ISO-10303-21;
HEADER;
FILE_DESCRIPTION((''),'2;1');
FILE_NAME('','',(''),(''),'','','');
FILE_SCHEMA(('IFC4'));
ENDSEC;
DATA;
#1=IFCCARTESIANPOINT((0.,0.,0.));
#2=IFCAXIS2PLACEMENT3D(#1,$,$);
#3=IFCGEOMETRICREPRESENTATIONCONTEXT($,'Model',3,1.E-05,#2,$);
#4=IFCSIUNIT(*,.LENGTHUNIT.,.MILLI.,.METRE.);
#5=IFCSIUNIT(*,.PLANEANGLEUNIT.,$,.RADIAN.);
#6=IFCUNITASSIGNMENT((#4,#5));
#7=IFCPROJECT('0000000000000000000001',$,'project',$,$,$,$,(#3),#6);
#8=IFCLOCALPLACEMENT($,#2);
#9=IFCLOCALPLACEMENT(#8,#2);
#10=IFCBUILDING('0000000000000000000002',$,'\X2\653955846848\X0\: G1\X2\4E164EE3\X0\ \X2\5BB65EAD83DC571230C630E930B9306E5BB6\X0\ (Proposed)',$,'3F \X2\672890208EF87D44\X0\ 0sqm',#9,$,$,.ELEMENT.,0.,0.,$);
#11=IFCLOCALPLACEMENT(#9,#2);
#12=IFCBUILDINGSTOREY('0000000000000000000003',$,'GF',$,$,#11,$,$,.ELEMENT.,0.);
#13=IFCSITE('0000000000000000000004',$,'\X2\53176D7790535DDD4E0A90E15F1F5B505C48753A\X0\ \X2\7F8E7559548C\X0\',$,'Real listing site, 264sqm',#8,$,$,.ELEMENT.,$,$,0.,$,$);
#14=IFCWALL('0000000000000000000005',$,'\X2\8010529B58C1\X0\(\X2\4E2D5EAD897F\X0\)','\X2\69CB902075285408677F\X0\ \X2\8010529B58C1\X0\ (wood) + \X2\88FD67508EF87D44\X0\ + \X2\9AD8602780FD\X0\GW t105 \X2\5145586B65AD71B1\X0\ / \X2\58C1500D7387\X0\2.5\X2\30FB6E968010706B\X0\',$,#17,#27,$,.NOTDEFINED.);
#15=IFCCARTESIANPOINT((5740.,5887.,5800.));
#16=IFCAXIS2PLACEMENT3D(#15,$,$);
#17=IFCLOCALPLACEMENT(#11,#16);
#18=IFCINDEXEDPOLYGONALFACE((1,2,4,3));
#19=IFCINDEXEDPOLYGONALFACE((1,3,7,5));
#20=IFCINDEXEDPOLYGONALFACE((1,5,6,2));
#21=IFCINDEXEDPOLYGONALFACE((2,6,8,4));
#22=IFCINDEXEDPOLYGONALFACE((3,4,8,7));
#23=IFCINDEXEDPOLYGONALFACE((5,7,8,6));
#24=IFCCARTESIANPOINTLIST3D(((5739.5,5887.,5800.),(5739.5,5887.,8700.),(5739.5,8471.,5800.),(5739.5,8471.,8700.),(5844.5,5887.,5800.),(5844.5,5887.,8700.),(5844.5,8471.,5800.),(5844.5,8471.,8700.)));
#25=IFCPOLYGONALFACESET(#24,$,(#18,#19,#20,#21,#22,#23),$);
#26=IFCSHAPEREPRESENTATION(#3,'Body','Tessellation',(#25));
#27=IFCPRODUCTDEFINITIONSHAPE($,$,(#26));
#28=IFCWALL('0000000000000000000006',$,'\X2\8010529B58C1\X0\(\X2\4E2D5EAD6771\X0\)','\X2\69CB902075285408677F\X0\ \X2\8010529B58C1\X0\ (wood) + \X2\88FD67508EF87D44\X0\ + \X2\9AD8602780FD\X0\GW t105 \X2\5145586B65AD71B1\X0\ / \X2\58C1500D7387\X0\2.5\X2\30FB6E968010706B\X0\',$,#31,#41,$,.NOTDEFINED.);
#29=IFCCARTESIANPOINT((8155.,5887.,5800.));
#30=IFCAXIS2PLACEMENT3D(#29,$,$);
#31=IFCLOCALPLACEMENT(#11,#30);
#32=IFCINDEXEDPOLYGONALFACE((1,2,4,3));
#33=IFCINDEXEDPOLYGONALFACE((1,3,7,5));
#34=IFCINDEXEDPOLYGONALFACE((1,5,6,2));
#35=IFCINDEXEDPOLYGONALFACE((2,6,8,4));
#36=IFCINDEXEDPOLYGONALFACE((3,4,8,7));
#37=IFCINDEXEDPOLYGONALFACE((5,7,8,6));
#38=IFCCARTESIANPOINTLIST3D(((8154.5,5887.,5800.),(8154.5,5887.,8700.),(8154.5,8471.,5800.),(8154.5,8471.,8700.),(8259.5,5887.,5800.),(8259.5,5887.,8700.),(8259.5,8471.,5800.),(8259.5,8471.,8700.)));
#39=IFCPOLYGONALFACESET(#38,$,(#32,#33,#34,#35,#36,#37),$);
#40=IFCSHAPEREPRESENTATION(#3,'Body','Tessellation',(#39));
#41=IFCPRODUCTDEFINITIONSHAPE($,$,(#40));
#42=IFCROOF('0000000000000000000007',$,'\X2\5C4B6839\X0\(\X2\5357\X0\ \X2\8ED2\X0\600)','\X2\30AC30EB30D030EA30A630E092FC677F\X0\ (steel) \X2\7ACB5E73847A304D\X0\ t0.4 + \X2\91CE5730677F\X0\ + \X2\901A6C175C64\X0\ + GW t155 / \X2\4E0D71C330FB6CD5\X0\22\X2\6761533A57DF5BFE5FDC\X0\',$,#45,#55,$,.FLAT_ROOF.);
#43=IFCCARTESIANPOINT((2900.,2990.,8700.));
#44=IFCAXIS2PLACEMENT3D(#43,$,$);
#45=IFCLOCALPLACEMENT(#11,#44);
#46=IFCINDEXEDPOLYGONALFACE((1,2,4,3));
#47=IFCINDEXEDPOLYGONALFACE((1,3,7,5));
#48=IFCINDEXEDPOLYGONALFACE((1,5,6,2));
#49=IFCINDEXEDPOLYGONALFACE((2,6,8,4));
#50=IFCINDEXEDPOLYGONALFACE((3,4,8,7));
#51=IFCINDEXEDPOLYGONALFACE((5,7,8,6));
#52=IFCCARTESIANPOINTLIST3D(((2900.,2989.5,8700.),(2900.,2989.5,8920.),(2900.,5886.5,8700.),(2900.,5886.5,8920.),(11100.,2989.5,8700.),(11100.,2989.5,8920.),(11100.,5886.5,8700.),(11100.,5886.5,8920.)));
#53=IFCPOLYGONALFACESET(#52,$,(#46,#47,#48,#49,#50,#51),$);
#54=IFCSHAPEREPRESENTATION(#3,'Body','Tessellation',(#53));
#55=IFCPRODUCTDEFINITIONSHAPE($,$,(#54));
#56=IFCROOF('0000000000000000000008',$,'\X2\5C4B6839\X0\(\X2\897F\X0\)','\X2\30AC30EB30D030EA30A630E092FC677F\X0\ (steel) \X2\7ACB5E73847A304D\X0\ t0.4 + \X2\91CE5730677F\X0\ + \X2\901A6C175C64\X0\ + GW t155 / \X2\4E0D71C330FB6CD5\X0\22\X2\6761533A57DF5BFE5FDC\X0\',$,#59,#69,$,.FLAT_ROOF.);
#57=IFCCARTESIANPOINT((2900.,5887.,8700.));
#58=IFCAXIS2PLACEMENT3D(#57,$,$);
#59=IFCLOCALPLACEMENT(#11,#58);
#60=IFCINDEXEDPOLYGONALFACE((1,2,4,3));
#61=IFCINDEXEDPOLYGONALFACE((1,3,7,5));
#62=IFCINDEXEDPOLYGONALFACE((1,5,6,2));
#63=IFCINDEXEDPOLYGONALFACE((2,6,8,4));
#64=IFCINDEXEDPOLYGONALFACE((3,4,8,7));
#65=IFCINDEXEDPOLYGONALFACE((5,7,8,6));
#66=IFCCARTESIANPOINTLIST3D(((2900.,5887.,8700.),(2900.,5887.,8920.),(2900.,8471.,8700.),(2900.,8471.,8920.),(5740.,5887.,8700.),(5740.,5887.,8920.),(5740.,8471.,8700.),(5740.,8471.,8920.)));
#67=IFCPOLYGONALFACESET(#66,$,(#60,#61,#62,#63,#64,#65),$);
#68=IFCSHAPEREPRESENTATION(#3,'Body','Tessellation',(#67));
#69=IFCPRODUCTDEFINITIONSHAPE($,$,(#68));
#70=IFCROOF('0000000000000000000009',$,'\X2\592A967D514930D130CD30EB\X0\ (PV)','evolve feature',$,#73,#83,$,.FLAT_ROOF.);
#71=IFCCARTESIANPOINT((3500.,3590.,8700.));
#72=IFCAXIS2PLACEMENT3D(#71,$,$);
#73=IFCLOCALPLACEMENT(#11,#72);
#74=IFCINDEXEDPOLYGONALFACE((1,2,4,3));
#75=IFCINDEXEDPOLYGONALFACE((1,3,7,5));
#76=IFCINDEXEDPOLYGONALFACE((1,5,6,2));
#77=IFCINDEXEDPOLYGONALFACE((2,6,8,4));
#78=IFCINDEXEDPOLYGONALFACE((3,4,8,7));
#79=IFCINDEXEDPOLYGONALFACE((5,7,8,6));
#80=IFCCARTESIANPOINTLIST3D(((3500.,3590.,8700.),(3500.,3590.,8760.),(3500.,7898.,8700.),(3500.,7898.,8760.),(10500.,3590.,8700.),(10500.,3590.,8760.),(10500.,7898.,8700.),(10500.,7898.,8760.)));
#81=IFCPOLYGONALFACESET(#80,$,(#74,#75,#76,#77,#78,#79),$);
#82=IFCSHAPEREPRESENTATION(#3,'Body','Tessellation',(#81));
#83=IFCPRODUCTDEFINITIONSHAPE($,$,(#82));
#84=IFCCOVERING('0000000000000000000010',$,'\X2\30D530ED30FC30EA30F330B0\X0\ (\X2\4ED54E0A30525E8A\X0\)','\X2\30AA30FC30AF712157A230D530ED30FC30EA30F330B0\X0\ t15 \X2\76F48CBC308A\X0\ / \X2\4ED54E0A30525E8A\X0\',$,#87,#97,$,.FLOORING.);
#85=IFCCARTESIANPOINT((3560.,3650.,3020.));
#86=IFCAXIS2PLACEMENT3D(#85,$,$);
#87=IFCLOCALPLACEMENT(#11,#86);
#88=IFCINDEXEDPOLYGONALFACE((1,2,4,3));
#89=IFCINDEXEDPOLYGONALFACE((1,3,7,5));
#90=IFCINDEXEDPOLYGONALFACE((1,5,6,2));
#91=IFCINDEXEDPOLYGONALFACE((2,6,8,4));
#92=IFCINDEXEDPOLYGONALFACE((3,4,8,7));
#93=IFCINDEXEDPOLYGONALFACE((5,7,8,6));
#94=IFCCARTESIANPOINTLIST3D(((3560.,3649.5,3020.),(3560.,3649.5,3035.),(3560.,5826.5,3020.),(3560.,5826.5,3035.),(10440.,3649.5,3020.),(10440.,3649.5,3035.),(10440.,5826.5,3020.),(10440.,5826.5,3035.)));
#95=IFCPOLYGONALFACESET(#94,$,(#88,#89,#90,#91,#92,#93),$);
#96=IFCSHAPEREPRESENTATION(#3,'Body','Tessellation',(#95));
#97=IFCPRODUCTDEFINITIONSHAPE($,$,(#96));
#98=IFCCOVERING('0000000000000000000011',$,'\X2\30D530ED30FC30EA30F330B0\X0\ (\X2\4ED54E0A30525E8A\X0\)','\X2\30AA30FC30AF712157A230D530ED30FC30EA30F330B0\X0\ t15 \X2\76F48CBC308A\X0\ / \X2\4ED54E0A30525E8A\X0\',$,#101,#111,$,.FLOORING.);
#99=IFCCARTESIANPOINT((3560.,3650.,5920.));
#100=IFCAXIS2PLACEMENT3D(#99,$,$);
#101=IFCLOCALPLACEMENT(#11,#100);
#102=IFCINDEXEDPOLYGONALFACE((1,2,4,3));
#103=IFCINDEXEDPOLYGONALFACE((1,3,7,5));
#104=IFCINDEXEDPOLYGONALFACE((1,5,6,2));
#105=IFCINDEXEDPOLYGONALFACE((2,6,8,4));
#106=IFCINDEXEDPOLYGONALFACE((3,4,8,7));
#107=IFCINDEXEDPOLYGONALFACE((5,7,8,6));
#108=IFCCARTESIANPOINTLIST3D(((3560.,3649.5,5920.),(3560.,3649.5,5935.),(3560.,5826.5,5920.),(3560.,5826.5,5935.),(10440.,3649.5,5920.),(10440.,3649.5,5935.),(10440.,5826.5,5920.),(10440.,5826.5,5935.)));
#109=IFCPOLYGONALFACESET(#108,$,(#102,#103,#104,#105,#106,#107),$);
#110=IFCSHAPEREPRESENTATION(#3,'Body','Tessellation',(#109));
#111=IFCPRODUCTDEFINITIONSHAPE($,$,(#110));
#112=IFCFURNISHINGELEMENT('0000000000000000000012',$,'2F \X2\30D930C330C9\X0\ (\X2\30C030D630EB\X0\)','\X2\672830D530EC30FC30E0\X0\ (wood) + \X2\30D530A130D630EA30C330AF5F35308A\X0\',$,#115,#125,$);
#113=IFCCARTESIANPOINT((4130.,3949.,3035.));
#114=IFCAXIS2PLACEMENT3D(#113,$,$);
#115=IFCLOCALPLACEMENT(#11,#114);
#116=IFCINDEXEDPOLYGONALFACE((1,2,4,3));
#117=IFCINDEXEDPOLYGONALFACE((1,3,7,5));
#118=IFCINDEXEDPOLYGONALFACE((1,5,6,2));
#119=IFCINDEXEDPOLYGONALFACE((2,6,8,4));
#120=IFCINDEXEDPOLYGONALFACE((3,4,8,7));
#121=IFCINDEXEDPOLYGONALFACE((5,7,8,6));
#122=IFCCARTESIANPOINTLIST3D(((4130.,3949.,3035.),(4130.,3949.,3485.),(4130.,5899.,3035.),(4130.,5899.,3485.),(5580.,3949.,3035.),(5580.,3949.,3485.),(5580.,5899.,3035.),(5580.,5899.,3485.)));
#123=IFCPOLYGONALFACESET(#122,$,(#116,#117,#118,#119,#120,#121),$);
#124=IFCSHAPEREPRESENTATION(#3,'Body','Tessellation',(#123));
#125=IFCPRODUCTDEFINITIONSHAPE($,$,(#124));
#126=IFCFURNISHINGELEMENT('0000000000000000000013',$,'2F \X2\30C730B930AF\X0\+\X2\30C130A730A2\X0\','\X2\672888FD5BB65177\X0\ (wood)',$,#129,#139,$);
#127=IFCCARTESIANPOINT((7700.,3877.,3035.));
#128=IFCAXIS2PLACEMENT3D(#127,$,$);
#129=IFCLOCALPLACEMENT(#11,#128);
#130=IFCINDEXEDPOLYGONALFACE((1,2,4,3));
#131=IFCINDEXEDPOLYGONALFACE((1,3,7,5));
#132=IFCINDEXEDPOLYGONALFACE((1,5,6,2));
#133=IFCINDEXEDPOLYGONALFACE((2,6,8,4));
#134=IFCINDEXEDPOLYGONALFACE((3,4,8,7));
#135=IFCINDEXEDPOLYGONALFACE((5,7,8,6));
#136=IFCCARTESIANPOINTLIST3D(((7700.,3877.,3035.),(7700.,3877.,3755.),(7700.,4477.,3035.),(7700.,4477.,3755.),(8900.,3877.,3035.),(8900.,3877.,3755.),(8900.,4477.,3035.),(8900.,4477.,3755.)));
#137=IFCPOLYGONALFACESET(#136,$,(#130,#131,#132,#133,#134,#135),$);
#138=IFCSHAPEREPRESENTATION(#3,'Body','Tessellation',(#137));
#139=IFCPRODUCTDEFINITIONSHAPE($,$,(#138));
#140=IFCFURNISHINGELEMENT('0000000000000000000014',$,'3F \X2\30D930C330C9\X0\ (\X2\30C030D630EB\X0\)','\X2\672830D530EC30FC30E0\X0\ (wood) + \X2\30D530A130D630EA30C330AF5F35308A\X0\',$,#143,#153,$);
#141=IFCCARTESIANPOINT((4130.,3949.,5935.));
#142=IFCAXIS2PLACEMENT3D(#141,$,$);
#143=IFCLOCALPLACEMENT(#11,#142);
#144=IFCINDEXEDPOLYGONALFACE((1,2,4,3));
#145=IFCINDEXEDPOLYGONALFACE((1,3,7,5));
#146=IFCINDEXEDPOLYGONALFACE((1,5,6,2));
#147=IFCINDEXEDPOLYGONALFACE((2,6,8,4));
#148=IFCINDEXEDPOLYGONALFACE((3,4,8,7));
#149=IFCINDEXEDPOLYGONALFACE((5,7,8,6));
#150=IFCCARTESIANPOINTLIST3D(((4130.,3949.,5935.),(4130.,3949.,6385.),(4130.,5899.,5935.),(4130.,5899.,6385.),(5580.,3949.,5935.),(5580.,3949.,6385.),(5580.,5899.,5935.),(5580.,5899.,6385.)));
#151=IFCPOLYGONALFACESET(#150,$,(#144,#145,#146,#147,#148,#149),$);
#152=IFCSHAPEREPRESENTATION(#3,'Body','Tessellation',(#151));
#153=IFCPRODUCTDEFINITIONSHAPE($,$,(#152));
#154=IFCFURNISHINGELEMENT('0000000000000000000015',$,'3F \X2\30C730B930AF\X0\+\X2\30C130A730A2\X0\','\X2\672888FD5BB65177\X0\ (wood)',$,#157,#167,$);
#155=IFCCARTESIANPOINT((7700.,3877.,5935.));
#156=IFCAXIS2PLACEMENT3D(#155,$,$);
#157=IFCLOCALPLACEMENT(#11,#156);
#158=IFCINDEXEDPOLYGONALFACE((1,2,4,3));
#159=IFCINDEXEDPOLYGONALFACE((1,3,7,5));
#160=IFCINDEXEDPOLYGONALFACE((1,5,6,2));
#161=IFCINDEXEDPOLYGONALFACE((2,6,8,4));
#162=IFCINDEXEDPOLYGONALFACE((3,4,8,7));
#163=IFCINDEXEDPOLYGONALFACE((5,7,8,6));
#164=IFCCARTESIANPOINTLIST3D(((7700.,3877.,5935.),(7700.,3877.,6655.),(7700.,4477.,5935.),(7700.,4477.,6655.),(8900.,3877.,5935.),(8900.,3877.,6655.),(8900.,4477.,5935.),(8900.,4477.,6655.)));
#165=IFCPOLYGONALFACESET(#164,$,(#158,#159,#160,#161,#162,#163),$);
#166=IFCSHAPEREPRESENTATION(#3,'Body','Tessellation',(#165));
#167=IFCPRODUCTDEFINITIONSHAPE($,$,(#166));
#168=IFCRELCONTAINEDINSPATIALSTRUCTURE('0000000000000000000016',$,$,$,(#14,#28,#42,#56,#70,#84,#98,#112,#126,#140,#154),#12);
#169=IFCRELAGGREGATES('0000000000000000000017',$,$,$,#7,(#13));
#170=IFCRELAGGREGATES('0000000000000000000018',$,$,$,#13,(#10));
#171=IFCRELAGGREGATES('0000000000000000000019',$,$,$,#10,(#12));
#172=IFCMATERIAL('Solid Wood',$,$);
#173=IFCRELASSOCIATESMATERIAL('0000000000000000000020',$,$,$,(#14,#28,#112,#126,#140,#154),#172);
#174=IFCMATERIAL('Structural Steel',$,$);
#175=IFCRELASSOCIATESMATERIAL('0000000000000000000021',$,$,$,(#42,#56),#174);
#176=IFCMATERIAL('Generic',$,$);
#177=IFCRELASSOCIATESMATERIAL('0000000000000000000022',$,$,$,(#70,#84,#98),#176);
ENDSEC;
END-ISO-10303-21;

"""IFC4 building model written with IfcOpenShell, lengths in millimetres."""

from ifc_helpers import new_model, si_unit, frame, frame_2d, origin, place, context, project, spatial, rectangle, extrude, material, element, save


model = new_model("IFC4")

# Units and contexts
model_context = context("Model", 3, precision=1e-05, world=origin())
ifc_project = project(units=[si_unit("LENGTHUNIT", "METRE", prefix="MILLI"), si_unit("PLANEANGLEUNIT", "RADIAN")], contexts=[model_context])

# Site, building, storey
site_placement = place(None, origin())
site = spatial("IfcSite", under=ifc_project, at=site_placement, Name="北海道川上郡弟子屈町 美留和", ObjectType="Real listing site, 264sqm", CompositionType="ELEMENT", RefElevation=0.0)
building_placement = place(site_placement, origin())
building = spatial("IfcBuilding", under=site, at=building_placement, Name="改善案: G1世代 家庭菜園テラスの家 (Proposed)", ObjectType="3F 木造軸組 0sqm", CompositionType="ELEMENT", ElevationOfRefHeight=0.0, ElevationOfTerrain=0.0)
storey_placement = place(building_placement, origin())
storey = spatial("IfcBuildingStorey", under=building, at=storey_placement, Name="GF", CompositionType="ELEMENT", Elevation=0.0)

# Shared definitions
ifc_material_1 = material(Name="Solid Wood")

# Walls
wall_1_placement = place(storey_placement, frame((5740.0, 5887.0, 5800.0)))
element("IfcWall", 1, at=wall_1_placement, inside=storey, material=ifc_material_1, Name="耐力壁(中庭西)", Description="構造用合板 耐力壁 (wood) + 製材軸組 + 高性能GW t105 充填断熱 / 壁倍率2.5・準耐火", PredefinedType="NOTDEFINED", context=model_context, shape_type="SweptSolid", body=[
    extrude(rectangle(XDim=105.0, YDim=2584.0, at=frame_2d((52.0, 1292.0))), frame((5740.0, 5887.0, 5800.0)), (0.0, 0.0, 1.0), 2900.0),
])
wall_2_placement = place(storey_placement, frame((8155.0, 5887.0, 5800.0)))
element("IfcWall", 2, at=wall_2_placement, inside=storey, material=ifc_material_1, Name="耐力壁(中庭東)", Description="構造用合板 耐力壁 (wood) + 製材軸組 + 高性能GW t105 充填断熱 / 壁倍率2.5・準耐火", PredefinedType="NOTDEFINED", context=model_context, shape_type="SweptSolid", body=[
    extrude(rectangle(XDim=105.0, YDim=2584.0, at=frame_2d((52.0, 1292.0))), frame((8155.0, 5887.0, 5800.0)), (0.0, 0.0, 1.0), 2900.0),
])

# Roofs
ifc_material_2 = material(Name="Structural Steel")
roof_1_placement = place(storey_placement, frame((2900.0, 2990.0, 8700.0)))
element("IfcRoof", 3, at=roof_1_placement, inside=storey, material=ifc_material_2, Name="屋根(南 軒600)", Description="ガルバリウム鋼板 (steel) 立平葺き t0.4 + 野地板 + 通気層 + GW t155 / 不燃・法22条区域対応", PredefinedType="FLAT_ROOF", context=model_context, shape_type="SweptSolid", body=[
    extrude(rectangle(XDim=8200.0, YDim=2897.0, at=frame_2d((4100.0, 1448.0))), frame((2900.0, 2990.0, 8700.0)), (0.0, 0.0, 1.0), 220.0),
])
roof_2_placement = place(storey_placement, frame((2900.0, 5887.0, 8700.0)))
element("IfcRoof", 4, at=roof_2_placement, inside=storey, material=ifc_material_2, Name="屋根(西)", Description="ガルバリウム鋼板 (steel) 立平葺き t0.4 + 野地板 + 通気層 + GW t155 / 不燃・法22条区域対応", PredefinedType="FLAT_ROOF", context=model_context, shape_type="SweptSolid", body=[
    extrude(rectangle(XDim=2840.0, YDim=2584.0, at=frame_2d((1420.0, 1292.0))), frame((2900.0, 5887.0, 8700.0)), (0.0, 0.0, 1.0), 220.0),
])
ifc_material_3 = material(Name="Generic")
roof_3_placement = place(storey_placement, frame((3500.0, 3590.0, 8700.0)))
element("IfcRoof", 5, at=roof_3_placement, inside=storey, material=ifc_material_3, Name="太陽光パネル (PV)", Description="evolve feature", PredefinedType="FLAT_ROOF", context=model_context, shape_type="SweptSolid", body=[
    extrude(rectangle(XDim=7000.0, YDim=4308.0, at=frame_2d((3500.0, 2154.0))), frame((3500.0, 3590.0, 8700.0)), (0.0, 0.0, 1.0), 60.0),
])

# Coverings
covering_1_placement = place(storey_placement, frame((3560.0, 3650.0, 3020.0)))
element("IfcCovering", 6, at=covering_1_placement, inside=storey, material=ifc_material_3, Name="フローリング (仕上げ床)", Description="オーク無垢フローリング t15 直貼り / 仕上げ床", PredefinedType="FLOORING", context=model_context, shape_type="SweptSolid", body=[
    extrude(rectangle(XDim=6880.0, YDim=2177.0, at=frame_2d((3440.0, 1088.0))), frame((3560.0, 3650.0, 3020.0)), (0.0, 0.0, 1.0), 15.0),
])
covering_2_placement = place(storey_placement, frame((3560.0, 3650.0, 5920.0)))
element("IfcCovering", 7, at=covering_2_placement, inside=storey, material=ifc_material_3, Name="フローリング (仕上げ床)", Description="オーク無垢フローリング t15 直貼り / 仕上げ床", PredefinedType="FLOORING", context=model_context, shape_type="SweptSolid", body=[
    extrude(rectangle(XDim=6880.0, YDim=2177.0, at=frame_2d((3440.0, 1088.0))), frame((3560.0, 3650.0, 5920.0)), (0.0, 0.0, 1.0), 15.0),
])

# Furnishing elements
furnishing_1_placement = place(storey_placement, frame((4130.0, 3949.0, 3035.0)))
element("IfcFurnishingElement", 8, at=furnishing_1_placement, inside=storey, material=ifc_material_1, Name="2F ベッド (ダブル)", Description="木フレーム (wood) + ファブリック張り", context=model_context, shape_type="SweptSolid", body=[
    extrude(rectangle(XDim=1450.0, YDim=1950.0, at=frame_2d((725.0, 975.0))), frame((4130.0, 3949.0, 3035.0)), (0.0, 0.0, 1.0), 450.0),
])
furnishing_2_placement = place(storey_placement, frame((7700.0, 3877.0, 3035.0)))
element("IfcFurnishingElement", 9, at=furnishing_2_placement, inside=storey, material=ifc_material_1, Name="2F デスク+チェア", Description="木製家具 (wood)", context=model_context, shape_type="SweptSolid", body=[
    extrude(rectangle(XDim=1200.0, YDim=600.0, at=frame_2d((600.0, 300.0))), frame((7700.0, 3877.0, 3035.0)), (0.0, 0.0, 1.0), 720.0),
])
furnishing_3_placement = place(storey_placement, frame((4130.0, 3949.0, 5935.0)))
element("IfcFurnishingElement", 10, at=furnishing_3_placement, inside=storey, material=ifc_material_1, Name="3F ベッド (ダブル)", Description="木フレーム (wood) + ファブリック張り", context=model_context, shape_type="SweptSolid", body=[
    extrude(rectangle(XDim=1450.0, YDim=1950.0, at=frame_2d((725.0, 975.0))), frame((4130.0, 3949.0, 5935.0)), (0.0, 0.0, 1.0), 450.0),
])
furnishing_4_placement = place(storey_placement, frame((7700.0, 3877.0, 5935.0)))
element("IfcFurnishingElement", 11, at=furnishing_4_placement, inside=storey, material=ifc_material_1, Name="3F デスク+チェア", Description="木製家具 (wood)", context=model_context, shape_type="SweptSolid", body=[
    extrude(rectangle(XDim=1200.0, YDim=600.0, at=frame_2d((600.0, 300.0))), frame((7700.0, 3877.0, 5935.0)), (0.0, 0.0, 1.0), 720.0),
])

save(model, "model.ifc")
